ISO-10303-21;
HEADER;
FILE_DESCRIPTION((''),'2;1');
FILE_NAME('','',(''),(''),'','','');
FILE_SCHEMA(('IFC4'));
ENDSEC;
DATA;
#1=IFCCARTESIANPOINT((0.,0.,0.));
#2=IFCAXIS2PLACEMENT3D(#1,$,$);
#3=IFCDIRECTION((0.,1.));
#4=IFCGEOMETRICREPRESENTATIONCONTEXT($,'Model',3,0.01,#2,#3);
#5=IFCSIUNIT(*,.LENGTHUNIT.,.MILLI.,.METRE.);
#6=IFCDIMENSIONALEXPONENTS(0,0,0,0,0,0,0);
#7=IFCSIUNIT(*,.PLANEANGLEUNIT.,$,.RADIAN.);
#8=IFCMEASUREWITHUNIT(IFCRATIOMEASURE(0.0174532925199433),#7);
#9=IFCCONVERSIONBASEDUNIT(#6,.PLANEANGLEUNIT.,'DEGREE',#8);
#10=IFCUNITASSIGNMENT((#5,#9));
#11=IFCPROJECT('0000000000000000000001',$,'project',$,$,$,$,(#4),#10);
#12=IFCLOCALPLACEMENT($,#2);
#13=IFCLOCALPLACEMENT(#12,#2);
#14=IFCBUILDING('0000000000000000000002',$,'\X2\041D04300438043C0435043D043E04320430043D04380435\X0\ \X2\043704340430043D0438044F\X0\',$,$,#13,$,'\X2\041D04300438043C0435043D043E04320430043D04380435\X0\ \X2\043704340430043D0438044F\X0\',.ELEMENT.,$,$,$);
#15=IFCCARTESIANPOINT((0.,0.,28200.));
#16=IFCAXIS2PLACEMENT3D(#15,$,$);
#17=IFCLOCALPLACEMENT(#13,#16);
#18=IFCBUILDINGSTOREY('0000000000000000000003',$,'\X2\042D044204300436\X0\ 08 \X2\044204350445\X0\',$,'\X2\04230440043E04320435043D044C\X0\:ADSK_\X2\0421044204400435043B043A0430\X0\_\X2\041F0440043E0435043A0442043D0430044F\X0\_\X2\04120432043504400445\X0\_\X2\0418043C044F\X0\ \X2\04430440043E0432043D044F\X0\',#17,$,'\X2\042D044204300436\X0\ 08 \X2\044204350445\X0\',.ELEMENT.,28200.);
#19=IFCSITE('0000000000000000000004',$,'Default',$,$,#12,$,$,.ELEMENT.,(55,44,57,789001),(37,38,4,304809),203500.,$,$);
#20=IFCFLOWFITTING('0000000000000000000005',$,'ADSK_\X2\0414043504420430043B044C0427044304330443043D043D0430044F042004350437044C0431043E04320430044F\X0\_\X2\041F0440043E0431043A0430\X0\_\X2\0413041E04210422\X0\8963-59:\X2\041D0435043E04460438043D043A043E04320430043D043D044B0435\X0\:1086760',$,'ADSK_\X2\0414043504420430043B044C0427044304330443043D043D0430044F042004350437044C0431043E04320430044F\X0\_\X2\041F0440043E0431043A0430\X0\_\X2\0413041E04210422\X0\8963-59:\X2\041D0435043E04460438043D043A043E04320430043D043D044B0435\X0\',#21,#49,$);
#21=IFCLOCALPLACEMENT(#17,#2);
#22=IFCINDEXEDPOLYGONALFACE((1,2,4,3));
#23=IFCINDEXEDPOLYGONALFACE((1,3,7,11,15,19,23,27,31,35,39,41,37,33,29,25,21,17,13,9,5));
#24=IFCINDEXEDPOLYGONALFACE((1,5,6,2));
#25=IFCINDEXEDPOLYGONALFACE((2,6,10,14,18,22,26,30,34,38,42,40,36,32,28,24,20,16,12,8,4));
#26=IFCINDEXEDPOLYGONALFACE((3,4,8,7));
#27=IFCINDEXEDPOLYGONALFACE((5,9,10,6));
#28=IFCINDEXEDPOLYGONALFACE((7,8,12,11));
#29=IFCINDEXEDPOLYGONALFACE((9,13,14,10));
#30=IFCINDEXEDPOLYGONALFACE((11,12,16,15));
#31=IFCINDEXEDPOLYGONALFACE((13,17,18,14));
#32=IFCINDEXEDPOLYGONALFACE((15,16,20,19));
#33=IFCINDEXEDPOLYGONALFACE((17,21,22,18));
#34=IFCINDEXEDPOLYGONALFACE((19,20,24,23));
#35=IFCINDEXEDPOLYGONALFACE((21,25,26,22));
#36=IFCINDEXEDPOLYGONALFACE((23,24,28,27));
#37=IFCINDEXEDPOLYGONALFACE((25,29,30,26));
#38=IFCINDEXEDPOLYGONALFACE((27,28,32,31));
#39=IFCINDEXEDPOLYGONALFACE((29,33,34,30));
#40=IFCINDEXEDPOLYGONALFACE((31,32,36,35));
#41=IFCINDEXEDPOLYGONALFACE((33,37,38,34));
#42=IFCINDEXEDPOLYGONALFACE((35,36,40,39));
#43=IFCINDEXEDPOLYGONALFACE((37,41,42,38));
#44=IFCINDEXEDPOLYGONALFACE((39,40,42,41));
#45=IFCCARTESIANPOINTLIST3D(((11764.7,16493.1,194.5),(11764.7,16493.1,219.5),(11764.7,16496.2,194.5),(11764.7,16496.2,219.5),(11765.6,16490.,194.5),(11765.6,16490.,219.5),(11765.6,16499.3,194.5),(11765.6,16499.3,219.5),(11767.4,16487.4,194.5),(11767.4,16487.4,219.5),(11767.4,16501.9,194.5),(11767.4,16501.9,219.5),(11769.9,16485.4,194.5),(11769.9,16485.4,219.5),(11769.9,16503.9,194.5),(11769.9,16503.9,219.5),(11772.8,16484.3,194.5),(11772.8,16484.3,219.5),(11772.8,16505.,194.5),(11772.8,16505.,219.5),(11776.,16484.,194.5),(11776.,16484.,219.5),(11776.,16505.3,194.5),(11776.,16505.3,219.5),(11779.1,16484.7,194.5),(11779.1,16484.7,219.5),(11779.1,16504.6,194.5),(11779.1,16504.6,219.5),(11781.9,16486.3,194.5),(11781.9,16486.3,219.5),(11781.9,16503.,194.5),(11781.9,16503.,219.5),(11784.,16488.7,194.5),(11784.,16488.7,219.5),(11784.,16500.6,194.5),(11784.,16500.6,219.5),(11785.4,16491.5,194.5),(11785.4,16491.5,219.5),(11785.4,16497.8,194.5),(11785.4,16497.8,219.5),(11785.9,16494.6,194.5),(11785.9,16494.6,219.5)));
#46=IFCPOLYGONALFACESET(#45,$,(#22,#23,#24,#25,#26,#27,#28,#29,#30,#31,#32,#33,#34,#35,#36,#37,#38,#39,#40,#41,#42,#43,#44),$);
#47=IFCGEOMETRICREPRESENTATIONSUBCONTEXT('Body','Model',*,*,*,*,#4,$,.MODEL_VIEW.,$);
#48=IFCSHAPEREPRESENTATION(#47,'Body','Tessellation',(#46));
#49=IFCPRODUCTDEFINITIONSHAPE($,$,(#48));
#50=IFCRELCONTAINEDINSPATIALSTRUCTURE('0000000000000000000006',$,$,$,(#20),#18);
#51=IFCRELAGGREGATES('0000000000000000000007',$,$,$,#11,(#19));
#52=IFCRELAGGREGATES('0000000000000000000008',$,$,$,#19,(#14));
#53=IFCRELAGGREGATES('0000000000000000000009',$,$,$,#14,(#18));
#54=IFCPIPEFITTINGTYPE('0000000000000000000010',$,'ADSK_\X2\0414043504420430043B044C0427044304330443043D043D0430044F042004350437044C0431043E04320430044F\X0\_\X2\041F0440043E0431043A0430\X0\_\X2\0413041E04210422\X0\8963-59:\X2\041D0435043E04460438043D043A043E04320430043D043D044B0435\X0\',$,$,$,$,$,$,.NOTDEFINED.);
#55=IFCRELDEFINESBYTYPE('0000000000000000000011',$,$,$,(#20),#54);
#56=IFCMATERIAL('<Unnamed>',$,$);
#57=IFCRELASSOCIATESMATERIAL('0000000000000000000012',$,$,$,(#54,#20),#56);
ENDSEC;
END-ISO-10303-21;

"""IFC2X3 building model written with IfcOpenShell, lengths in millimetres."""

from ifc_helpers import new_model, entity, si_unit, converted_unit, direction, frame, origin, origin_2d_with_axis, place, context, subcontext, project, spatial, circle, extrude, source, transform, mapped, material, type_object, type_shapes, element, save


model = new_model("IFC2X3")

# Units and contexts
model_context = context("Model", 3, precision=0.01, world=origin(), true_north=direction((0.0, 1.0)))
body_context = subcontext(model_context, "Body", "Model", "MODEL_VIEW")
ifc_project = project(units=[si_unit("LENGTHUNIT", "METRE", prefix="MILLI"), converted_unit("PLANEANGLEUNIT", "DEGREE", entity("IfcRatioMeasure", 0.0174532925199433), si_unit("PLANEANGLEUNIT", "RADIAN"), dimensions=[0, 0, 0, 0, 0, 0, 0])], contexts=[model_context])

# Site, building, storey
site_placement = place(None, origin())
site = spatial("IfcSite", under=ifc_project, at=site_placement, Name="Default", CompositionType="ELEMENT", RefLatitude=(55, 44, 57, 789001), RefLongitude=(37, 38, 4, 304809), RefElevation=203500.0)
building_placement = place(site_placement, origin())
building = spatial("IfcBuilding", under=site, at=building_placement, Name="Наименование здания", LongName="Наименование здания", CompositionType="ELEMENT")
storey_placement = place(building_placement, frame((0.0, 0.0, 28200.0)))
storey = spatial("IfcBuildingStorey", under=building, at=storey_placement, Name="Этаж 08 тех", ObjectType="Уровень:ADSK_Стрелка_Проектная_Вверх_Имя уровня", LongName="Этаж 08 тех", CompositionType="ELEMENT", Elevation=28200.0)

# Shared definitions
ifc_material = material(Name="<Unnamed>")

# Flow fitting
pipe_fitting_type_1 = type_object("IfcPipeFittingType", Name="ADSK_ДетальЧугуннаяРезьбовая_Пробка_ГОСТ8963-59:Неоцинкованные", PredefinedType="NOTDEFINED", material=ifc_material)
shared_shape_1 = source(origin(), body_context, "Body", "SweptSolid", [
    extrude(circle(Radius=10.7, at=origin_2d_with_axis()), frame((0.0, 0.0, 0.0), z_axis=(1.0, 0.0, 0.0), x_axis=(0.0, 1.0, 0.0)), (0.0, 0.0, 1.0), 25.0),
])
type_shapes(pipe_fitting_type_1, [shared_shape_1])
flow_fitting_placement = place(storey_placement, frame((11775.2, 16494.7, 219.5), z_axis=(0.0, -1.0, 0.0), x_axis=(0.0, 0.0, -1.0)))
element("IfcFlowFitting", 1, at=flow_fitting_placement, inside=storey, type_object=pipe_fitting_type_1, material=ifc_material, Name="ADSK_ДетальЧугуннаяРезьбовая_Пробка_ГОСТ8963-59:Неоцинкованные:1086760", ObjectType="ADSK_ДетальЧугуннаяРезьбовая_Пробка_ГОСТ8963-59:Неоцинкованные", context=body_context, shape_type="MappedRepresentation", body=[
    mapped(shared_shape_1, transform((0.0, 0.0, 0.0), scale=1.0)),
])

save(model, "model.ifc")
